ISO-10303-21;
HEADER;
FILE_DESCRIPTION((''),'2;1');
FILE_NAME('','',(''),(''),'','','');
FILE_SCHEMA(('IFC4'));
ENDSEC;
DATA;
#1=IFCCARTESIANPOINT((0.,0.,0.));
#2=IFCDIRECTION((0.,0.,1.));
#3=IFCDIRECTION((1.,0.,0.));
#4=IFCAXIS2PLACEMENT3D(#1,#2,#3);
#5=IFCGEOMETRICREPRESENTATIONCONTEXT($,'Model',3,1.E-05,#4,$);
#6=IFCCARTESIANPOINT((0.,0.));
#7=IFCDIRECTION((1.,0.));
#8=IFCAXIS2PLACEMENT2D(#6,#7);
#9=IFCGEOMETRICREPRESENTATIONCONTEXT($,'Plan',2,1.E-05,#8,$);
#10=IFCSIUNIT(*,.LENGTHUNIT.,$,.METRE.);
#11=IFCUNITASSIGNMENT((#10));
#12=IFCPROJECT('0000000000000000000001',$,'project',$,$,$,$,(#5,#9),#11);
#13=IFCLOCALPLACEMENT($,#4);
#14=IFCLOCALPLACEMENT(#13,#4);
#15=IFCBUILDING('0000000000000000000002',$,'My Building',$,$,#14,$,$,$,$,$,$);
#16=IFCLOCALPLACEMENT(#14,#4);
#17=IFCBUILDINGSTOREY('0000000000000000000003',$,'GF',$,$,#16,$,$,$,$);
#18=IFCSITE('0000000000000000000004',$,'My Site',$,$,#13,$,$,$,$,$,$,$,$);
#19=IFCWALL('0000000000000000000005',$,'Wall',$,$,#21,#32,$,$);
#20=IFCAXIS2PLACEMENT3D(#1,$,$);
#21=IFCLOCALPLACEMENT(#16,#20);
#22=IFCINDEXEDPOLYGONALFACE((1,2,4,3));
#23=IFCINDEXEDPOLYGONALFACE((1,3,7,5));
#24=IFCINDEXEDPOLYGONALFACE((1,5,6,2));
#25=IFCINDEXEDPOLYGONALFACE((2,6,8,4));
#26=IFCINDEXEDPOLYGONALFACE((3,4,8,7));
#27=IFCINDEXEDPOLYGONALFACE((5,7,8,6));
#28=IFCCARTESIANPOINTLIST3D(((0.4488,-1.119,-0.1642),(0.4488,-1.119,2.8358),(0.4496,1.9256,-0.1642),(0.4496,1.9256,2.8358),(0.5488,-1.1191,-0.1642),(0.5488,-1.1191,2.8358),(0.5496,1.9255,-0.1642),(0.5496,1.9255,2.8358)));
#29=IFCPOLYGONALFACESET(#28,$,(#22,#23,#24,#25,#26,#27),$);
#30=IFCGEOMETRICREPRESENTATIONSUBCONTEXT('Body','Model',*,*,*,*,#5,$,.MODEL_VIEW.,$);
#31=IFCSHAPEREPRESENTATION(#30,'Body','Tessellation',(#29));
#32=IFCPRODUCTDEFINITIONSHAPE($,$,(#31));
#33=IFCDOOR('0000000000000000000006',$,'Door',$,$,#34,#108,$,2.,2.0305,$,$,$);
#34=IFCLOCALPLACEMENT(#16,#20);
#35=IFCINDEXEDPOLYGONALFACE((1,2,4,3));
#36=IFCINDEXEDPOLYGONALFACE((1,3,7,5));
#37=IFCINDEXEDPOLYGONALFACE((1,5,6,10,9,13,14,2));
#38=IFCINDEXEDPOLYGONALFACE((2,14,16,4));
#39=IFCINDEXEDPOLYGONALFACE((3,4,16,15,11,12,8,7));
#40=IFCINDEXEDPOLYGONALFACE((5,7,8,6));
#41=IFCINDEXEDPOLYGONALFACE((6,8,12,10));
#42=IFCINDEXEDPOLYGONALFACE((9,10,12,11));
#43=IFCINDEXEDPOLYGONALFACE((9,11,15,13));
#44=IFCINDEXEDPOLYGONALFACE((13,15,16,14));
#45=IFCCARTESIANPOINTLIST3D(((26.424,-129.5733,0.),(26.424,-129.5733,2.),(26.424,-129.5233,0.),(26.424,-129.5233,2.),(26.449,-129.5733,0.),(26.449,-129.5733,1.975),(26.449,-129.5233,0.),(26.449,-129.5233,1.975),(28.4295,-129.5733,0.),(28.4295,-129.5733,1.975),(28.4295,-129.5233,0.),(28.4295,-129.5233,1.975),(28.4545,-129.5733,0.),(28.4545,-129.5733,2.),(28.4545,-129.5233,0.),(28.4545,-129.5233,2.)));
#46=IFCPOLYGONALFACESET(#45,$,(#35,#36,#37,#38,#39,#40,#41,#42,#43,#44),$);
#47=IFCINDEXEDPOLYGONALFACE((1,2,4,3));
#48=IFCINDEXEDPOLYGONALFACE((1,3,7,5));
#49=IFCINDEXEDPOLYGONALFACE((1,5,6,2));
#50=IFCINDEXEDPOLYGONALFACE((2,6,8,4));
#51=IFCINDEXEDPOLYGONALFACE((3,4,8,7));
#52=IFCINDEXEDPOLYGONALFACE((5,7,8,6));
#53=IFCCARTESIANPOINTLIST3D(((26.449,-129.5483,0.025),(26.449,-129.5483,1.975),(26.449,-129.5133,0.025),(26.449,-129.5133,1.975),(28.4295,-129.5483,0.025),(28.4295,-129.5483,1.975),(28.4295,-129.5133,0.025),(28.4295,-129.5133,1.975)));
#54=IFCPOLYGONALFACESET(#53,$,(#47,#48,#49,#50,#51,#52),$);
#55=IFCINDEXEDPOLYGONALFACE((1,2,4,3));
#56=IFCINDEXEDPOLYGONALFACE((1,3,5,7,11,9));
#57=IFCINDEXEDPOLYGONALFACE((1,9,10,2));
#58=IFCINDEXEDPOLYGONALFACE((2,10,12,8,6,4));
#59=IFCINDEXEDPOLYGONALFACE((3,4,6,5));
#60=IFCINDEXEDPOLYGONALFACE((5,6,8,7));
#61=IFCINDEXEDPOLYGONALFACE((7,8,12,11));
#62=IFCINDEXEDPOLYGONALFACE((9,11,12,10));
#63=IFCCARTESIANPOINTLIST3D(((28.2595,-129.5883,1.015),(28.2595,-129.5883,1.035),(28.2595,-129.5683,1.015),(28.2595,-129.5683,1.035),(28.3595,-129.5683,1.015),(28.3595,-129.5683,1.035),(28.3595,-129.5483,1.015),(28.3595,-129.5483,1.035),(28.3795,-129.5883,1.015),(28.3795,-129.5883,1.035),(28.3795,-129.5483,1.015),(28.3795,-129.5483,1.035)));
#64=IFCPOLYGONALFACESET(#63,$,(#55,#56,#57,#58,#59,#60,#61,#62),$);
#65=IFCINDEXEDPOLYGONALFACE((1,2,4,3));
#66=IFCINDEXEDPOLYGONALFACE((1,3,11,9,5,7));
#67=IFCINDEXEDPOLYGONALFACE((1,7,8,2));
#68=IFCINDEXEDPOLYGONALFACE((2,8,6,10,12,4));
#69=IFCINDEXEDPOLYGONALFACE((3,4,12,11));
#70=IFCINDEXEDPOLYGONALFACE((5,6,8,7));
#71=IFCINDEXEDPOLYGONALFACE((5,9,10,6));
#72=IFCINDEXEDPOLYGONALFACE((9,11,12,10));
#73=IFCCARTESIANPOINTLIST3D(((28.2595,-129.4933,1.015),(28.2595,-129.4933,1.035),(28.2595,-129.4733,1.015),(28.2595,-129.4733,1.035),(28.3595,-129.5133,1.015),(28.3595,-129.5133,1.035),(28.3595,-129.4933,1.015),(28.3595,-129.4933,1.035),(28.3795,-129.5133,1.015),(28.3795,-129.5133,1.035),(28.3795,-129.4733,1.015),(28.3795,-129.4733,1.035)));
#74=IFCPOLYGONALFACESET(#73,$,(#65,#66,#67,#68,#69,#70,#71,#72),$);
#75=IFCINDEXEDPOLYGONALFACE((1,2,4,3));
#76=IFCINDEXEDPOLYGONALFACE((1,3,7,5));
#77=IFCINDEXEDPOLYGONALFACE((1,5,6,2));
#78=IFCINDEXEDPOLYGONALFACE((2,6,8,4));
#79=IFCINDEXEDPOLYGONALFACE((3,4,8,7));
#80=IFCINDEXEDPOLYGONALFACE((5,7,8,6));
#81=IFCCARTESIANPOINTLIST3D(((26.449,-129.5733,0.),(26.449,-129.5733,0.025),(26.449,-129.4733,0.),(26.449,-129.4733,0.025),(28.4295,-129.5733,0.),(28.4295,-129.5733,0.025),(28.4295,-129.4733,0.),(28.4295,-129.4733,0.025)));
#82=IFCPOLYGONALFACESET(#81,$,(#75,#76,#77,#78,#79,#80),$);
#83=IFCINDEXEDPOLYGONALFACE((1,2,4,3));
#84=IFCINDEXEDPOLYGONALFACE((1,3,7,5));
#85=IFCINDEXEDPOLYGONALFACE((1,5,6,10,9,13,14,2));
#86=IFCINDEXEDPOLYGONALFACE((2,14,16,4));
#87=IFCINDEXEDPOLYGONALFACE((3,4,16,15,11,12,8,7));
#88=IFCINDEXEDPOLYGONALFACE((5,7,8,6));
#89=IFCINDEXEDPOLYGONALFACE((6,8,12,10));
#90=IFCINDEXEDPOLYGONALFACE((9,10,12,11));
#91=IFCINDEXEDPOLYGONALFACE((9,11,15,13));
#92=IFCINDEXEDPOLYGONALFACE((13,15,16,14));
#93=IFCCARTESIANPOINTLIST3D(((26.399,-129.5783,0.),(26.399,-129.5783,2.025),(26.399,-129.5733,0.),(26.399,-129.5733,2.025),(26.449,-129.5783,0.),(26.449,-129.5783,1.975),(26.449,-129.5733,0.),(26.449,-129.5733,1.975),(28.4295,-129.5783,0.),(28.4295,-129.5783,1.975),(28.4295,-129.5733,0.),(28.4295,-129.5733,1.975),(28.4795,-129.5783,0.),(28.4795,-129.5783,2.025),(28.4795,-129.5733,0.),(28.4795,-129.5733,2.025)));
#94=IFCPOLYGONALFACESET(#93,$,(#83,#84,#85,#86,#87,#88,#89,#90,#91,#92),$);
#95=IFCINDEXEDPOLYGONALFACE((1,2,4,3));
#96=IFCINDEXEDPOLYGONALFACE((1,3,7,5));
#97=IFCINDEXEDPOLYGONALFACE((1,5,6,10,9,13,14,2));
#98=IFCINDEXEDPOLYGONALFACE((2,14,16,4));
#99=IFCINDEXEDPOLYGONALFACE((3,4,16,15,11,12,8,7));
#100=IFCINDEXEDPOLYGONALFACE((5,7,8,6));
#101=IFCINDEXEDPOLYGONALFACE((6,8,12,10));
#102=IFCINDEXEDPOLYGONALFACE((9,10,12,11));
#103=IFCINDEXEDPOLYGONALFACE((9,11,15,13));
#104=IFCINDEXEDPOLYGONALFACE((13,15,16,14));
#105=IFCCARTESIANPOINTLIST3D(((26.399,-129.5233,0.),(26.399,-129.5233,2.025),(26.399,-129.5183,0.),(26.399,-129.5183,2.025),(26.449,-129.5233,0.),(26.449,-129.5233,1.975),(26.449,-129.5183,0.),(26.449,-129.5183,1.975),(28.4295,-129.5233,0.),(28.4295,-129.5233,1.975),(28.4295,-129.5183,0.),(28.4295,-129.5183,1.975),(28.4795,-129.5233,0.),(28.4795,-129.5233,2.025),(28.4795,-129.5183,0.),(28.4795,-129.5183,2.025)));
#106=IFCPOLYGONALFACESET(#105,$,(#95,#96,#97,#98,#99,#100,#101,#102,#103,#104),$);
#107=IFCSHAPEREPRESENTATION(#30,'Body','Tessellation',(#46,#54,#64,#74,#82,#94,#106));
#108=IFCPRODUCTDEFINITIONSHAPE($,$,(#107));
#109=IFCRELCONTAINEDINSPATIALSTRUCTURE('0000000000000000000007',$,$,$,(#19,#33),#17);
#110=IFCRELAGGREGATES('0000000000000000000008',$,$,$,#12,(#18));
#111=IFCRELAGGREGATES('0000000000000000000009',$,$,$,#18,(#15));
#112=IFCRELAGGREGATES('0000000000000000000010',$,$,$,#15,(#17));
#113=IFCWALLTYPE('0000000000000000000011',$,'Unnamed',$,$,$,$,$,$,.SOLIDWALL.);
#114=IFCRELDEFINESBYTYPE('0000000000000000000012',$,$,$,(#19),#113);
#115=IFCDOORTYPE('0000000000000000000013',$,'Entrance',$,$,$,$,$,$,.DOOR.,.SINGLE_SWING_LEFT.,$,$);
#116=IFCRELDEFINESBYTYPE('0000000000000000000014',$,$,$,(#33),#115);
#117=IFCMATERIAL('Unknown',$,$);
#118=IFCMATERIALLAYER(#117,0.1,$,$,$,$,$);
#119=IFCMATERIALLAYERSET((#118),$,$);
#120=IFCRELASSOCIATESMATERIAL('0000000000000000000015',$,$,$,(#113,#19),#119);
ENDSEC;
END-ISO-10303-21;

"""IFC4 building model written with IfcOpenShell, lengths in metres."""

from ifc_helpers import new_model, entity, si_unit, frame, origin_with_axes, origin_2d_with_axis, place, context, subcontext, project, spatial, line, indexed_curve, outline, extrude, shape, source, transform, mapped, material, layer, layer_set, layer_usage, type_object, type_shapes, element, save


model = new_model("IFC4")

# Units and contexts
model_context = context("Model", 3, precision=1e-05, world=origin_with_axes())
plan_context = context("Plan", 2, precision=1e-05, world=origin_2d_with_axis())
body_context_1 = subcontext(model_context, "Body", "Model", "MODEL_VIEW")
body_context_2 = subcontext(plan_context, "Body", "Plan", "PLAN_VIEW")
ifc_project = project(units=[si_unit("LENGTHUNIT", "METRE")], contexts=[model_context, plan_context])

# Site, building, storey
site_placement = place(None, origin_with_axes())
site = spatial("IfcSite", under=ifc_project, at=site_placement, Name="My Site")
building_placement = place(site_placement, origin_with_axes())
building = spatial("IfcBuilding", under=site, at=building_placement, Name="My Building")
storey_placement = place(building_placement, origin_with_axes())
storey = spatial("IfcBuildingStorey", under=building, at=storey_placement, Name="GF")

# Shared definitions
ifc_material = material(Name="Unknown")

# Shared definitions
ifc_layer_1 = layer(ifc_material, 0.1)
ifc_layer_set_1 = layer_set([ifc_layer_1])
wall_type = type_object("IfcWallType", Name="Unnamed", PredefinedType="SOLIDWALL", material=ifc_layer_set_1)

# Shared definitions
door_type_1 = type_object("IfcDoorType", Name="Entrance", OperationType="SINGLE_SWING_LEFT", PredefinedType="DOOR")
shared_shape_1 = source(origin_with_axes(), body_context_1, "Body", "SweptSolid", [
    extrude(outline(indexed_curve([(0.0, 0.0), (0.0, 2.0), (2.0305, 2.0), (2.0305, 0.0), (2.0055, 0.0), (2.0055, 1.975), (0.025, 1.975), (0.025, 0.0)], segments=[line(1, 2, 3, 4, 5, 6, 7, 8, 1)])), frame((0.0, 0.0, 0.0), z_axis=(0.0, -1.0, 0.0), x_axis=(1.0, 0.0, 0.0)), (0.0, 0.0, -1.0), 0.05),
    extrude(outline(indexed_curve([(0.0, 0.0), (1.9805, 0.0), (1.9805, 0.035), (0.0, 0.035)], segments=[line(1, 2, 3, 4, 1)])), frame((0.025, 0.025, 0.025), z_axis=(0.0, 0.0, 1.0), x_axis=(1.0, 0.0, 0.0)), (0.0, 0.0, 1.0), 1.95),
    extrude(outline(indexed_curve([(0.0, 0.0), (0.0, -0.04), (-0.12, -0.04), (-0.12, -0.02), (-0.02, -0.02), (-0.02, 0.0)], segments=[line(1, 2, 3, 4, 5, 6, 1)])), frame((1.9555, 0.025, 1.015), z_axis=(0.0, 0.0, 1.0), x_axis=(1.0, 0.0, 0.0)), (0.0, 0.0, 1.0), 0.02),
    extrude(outline(indexed_curve([(0.0, 0.0), (0.0, 0.04), (-0.12, 0.04), (-0.12, 0.02), (-0.02, 0.02), (-0.02, 0.0)], segments=[line(1, 2, 3, 4, 5, 6, 1)])), frame((1.9555, 0.06, 1.015), z_axis=(0.0, 0.0, 1.0), x_axis=(1.0, 0.0, 0.0)), (0.0, 0.0, 1.0), 0.02),
    extrude(outline(indexed_curve([(0.0, 0.0), (1.9805, 0.0), (1.9805, 0.1), (0.0, 0.1)], segments=[line(1, 2, 3, 4, 1)])), frame((0.025, 0.0, 0.0), z_axis=(0.0, 0.0, 1.0), x_axis=(1.0, 0.0, 0.0)), (0.0, 0.0, 1.0), 0.025),
    extrude(outline(indexed_curve([(0.0, 0.0), (0.0, 2.025), (2.0805, 2.025), (2.0805, 0.0), (2.0305, 0.0), (2.0305, 1.975), (0.05, 1.975), (0.05, 0.0)], segments=[line(1, 2, 3, 4, 5, 6, 7, 8, 1)])), frame((-0.025, -0.005, 0.0), z_axis=(0.0, -1.0, 0.0), x_axis=(1.0, 0.0, 0.0)), (0.0, 0.0, -1.0), 0.005),
    extrude(outline(indexed_curve([(0.0, 0.0), (0.0, 2.025), (2.0805, 2.025), (2.0805, 0.0), (2.0305, 0.0), (2.0305, 1.975), (0.05, 1.975), (0.05, 0.0)], segments=[line(1, 2, 3, 4, 5, 6, 7, 8, 1)])), frame((-0.025, 0.05, 0.0), z_axis=(0.0, -1.0, 0.0), x_axis=(1.0, 0.0, 0.0)), (0.0, 0.0, -1.0), 0.005),
])
shared_shape_2 = source(origin_with_axes(), body_context_2, "Body", "Curve2D", [
    entity("IfcIndexedPolyCurve", entity("IfcCartesianPointList2D", [[0.0, 0.0], [0.025, 0.0], [0.025, 0.05], [0.0, 0.05]]), [entity("IfcLineIndex", [1, 2, 3, 4, 1])]),
    entity("IfcIndexedPolyCurve", entity("IfcCartesianPointList2D", [[2.0305, 0.0], [2.0055, 0.0], [2.0055, 0.05], [2.0305, 0.05]]), [entity("IfcLineIndex", [1, 2, 3, 4, 1])]),
    entity("IfcIndexedPolyCurve", entity("IfcCartesianPointList2D", [[0.025, 0.05], [0.025, -1.9305], [0.06, -1.9305]])),
    entity("IfcTrimmedCurve", entity("IfcEllipse", entity("IfcAxis2Placement2D", entity("IfcCartesianPoint", [0.06, 0.05]), entity("IfcDirection", [1.0, 0.0])), 1.9455, 1.9805), [entity("IfcCartesianPoint", [0.06, -1.9305])], [entity("IfcCartesianPoint", [0.06, 2.0305])], True, "CARTESIAN"),
    entity("IfcIndexedPolyCurve", entity("IfcCartesianPointList2D", [[0.025, 0.05], [0.06, 0.05], [0.06, 2.0305], [0.025, 2.0305]]), [entity("IfcLineIndex", [1, 2, 3, 4, 1])]),
])
type_shapes(door_type_1, [shared_shape_1, shared_shape_2])

# Wall
ifc_layer_usage_1 = layer_usage(ifc_layer_set_1, "AXIS2", "POSITIVE", 0.0)
wall_1_placement = place(storey_placement, frame((0.4496, 1.9256, -0.1642), z_axis=(0.0, 0.0, 1.0), x_axis=(-0.000261, -1.0, 0.0)))
element("IfcWall", 1, at=wall_1_placement, inside=storey, type_object=wall_type, material=ifc_layer_usage_1, Name="Wall", context=body_context_1, shape_type="SweptSolid", body=[
    extrude(outline(indexed_curve([(0.0, 0.0), (0.0, 0.1), (3.0446, 0.1), (3.0446, 0.0)], segments=[line(1, 2, 3, 4, 1)])), origin_with_axes(), (0.0, 0.0, 1.0), 3.0),
])

# Door
door_1_placement = place(storey_placement, frame((26.424, -129.5733, 0.0), z_axis=(0.0, 0.0, 1.0), x_axis=(1.0, 0.0, 0.0)))
element("IfcDoor", 2, at=door_1_placement, inside=storey, type_object=door_type_1, Name="Door", OverallHeight=2.0, OverallWidth=2.0305, shapes=[
    shape(body_context_1, "Body", "MappedRepresentation", [mapped(shared_shape_1, transform((0.0, 0.0, 0.0), x_axis=(1.0, 0.0, 0.0), y_axis=(0.0, 1.0, 0.0), z_axis=(0.0, 0.0, 1.0), scale=1.0))]),
    shape(body_context_2, "Body", "MappedRepresentation", [mapped(shared_shape_2, transform((0.0, 0.0, 0.0), x_axis=(1.0, 0.0, 0.0), y_axis=(0.0, 1.0, 0.0), z_axis=(0.0, 0.0, 1.0), scale=1.0))]),
])

save(model, "model.ifc")
